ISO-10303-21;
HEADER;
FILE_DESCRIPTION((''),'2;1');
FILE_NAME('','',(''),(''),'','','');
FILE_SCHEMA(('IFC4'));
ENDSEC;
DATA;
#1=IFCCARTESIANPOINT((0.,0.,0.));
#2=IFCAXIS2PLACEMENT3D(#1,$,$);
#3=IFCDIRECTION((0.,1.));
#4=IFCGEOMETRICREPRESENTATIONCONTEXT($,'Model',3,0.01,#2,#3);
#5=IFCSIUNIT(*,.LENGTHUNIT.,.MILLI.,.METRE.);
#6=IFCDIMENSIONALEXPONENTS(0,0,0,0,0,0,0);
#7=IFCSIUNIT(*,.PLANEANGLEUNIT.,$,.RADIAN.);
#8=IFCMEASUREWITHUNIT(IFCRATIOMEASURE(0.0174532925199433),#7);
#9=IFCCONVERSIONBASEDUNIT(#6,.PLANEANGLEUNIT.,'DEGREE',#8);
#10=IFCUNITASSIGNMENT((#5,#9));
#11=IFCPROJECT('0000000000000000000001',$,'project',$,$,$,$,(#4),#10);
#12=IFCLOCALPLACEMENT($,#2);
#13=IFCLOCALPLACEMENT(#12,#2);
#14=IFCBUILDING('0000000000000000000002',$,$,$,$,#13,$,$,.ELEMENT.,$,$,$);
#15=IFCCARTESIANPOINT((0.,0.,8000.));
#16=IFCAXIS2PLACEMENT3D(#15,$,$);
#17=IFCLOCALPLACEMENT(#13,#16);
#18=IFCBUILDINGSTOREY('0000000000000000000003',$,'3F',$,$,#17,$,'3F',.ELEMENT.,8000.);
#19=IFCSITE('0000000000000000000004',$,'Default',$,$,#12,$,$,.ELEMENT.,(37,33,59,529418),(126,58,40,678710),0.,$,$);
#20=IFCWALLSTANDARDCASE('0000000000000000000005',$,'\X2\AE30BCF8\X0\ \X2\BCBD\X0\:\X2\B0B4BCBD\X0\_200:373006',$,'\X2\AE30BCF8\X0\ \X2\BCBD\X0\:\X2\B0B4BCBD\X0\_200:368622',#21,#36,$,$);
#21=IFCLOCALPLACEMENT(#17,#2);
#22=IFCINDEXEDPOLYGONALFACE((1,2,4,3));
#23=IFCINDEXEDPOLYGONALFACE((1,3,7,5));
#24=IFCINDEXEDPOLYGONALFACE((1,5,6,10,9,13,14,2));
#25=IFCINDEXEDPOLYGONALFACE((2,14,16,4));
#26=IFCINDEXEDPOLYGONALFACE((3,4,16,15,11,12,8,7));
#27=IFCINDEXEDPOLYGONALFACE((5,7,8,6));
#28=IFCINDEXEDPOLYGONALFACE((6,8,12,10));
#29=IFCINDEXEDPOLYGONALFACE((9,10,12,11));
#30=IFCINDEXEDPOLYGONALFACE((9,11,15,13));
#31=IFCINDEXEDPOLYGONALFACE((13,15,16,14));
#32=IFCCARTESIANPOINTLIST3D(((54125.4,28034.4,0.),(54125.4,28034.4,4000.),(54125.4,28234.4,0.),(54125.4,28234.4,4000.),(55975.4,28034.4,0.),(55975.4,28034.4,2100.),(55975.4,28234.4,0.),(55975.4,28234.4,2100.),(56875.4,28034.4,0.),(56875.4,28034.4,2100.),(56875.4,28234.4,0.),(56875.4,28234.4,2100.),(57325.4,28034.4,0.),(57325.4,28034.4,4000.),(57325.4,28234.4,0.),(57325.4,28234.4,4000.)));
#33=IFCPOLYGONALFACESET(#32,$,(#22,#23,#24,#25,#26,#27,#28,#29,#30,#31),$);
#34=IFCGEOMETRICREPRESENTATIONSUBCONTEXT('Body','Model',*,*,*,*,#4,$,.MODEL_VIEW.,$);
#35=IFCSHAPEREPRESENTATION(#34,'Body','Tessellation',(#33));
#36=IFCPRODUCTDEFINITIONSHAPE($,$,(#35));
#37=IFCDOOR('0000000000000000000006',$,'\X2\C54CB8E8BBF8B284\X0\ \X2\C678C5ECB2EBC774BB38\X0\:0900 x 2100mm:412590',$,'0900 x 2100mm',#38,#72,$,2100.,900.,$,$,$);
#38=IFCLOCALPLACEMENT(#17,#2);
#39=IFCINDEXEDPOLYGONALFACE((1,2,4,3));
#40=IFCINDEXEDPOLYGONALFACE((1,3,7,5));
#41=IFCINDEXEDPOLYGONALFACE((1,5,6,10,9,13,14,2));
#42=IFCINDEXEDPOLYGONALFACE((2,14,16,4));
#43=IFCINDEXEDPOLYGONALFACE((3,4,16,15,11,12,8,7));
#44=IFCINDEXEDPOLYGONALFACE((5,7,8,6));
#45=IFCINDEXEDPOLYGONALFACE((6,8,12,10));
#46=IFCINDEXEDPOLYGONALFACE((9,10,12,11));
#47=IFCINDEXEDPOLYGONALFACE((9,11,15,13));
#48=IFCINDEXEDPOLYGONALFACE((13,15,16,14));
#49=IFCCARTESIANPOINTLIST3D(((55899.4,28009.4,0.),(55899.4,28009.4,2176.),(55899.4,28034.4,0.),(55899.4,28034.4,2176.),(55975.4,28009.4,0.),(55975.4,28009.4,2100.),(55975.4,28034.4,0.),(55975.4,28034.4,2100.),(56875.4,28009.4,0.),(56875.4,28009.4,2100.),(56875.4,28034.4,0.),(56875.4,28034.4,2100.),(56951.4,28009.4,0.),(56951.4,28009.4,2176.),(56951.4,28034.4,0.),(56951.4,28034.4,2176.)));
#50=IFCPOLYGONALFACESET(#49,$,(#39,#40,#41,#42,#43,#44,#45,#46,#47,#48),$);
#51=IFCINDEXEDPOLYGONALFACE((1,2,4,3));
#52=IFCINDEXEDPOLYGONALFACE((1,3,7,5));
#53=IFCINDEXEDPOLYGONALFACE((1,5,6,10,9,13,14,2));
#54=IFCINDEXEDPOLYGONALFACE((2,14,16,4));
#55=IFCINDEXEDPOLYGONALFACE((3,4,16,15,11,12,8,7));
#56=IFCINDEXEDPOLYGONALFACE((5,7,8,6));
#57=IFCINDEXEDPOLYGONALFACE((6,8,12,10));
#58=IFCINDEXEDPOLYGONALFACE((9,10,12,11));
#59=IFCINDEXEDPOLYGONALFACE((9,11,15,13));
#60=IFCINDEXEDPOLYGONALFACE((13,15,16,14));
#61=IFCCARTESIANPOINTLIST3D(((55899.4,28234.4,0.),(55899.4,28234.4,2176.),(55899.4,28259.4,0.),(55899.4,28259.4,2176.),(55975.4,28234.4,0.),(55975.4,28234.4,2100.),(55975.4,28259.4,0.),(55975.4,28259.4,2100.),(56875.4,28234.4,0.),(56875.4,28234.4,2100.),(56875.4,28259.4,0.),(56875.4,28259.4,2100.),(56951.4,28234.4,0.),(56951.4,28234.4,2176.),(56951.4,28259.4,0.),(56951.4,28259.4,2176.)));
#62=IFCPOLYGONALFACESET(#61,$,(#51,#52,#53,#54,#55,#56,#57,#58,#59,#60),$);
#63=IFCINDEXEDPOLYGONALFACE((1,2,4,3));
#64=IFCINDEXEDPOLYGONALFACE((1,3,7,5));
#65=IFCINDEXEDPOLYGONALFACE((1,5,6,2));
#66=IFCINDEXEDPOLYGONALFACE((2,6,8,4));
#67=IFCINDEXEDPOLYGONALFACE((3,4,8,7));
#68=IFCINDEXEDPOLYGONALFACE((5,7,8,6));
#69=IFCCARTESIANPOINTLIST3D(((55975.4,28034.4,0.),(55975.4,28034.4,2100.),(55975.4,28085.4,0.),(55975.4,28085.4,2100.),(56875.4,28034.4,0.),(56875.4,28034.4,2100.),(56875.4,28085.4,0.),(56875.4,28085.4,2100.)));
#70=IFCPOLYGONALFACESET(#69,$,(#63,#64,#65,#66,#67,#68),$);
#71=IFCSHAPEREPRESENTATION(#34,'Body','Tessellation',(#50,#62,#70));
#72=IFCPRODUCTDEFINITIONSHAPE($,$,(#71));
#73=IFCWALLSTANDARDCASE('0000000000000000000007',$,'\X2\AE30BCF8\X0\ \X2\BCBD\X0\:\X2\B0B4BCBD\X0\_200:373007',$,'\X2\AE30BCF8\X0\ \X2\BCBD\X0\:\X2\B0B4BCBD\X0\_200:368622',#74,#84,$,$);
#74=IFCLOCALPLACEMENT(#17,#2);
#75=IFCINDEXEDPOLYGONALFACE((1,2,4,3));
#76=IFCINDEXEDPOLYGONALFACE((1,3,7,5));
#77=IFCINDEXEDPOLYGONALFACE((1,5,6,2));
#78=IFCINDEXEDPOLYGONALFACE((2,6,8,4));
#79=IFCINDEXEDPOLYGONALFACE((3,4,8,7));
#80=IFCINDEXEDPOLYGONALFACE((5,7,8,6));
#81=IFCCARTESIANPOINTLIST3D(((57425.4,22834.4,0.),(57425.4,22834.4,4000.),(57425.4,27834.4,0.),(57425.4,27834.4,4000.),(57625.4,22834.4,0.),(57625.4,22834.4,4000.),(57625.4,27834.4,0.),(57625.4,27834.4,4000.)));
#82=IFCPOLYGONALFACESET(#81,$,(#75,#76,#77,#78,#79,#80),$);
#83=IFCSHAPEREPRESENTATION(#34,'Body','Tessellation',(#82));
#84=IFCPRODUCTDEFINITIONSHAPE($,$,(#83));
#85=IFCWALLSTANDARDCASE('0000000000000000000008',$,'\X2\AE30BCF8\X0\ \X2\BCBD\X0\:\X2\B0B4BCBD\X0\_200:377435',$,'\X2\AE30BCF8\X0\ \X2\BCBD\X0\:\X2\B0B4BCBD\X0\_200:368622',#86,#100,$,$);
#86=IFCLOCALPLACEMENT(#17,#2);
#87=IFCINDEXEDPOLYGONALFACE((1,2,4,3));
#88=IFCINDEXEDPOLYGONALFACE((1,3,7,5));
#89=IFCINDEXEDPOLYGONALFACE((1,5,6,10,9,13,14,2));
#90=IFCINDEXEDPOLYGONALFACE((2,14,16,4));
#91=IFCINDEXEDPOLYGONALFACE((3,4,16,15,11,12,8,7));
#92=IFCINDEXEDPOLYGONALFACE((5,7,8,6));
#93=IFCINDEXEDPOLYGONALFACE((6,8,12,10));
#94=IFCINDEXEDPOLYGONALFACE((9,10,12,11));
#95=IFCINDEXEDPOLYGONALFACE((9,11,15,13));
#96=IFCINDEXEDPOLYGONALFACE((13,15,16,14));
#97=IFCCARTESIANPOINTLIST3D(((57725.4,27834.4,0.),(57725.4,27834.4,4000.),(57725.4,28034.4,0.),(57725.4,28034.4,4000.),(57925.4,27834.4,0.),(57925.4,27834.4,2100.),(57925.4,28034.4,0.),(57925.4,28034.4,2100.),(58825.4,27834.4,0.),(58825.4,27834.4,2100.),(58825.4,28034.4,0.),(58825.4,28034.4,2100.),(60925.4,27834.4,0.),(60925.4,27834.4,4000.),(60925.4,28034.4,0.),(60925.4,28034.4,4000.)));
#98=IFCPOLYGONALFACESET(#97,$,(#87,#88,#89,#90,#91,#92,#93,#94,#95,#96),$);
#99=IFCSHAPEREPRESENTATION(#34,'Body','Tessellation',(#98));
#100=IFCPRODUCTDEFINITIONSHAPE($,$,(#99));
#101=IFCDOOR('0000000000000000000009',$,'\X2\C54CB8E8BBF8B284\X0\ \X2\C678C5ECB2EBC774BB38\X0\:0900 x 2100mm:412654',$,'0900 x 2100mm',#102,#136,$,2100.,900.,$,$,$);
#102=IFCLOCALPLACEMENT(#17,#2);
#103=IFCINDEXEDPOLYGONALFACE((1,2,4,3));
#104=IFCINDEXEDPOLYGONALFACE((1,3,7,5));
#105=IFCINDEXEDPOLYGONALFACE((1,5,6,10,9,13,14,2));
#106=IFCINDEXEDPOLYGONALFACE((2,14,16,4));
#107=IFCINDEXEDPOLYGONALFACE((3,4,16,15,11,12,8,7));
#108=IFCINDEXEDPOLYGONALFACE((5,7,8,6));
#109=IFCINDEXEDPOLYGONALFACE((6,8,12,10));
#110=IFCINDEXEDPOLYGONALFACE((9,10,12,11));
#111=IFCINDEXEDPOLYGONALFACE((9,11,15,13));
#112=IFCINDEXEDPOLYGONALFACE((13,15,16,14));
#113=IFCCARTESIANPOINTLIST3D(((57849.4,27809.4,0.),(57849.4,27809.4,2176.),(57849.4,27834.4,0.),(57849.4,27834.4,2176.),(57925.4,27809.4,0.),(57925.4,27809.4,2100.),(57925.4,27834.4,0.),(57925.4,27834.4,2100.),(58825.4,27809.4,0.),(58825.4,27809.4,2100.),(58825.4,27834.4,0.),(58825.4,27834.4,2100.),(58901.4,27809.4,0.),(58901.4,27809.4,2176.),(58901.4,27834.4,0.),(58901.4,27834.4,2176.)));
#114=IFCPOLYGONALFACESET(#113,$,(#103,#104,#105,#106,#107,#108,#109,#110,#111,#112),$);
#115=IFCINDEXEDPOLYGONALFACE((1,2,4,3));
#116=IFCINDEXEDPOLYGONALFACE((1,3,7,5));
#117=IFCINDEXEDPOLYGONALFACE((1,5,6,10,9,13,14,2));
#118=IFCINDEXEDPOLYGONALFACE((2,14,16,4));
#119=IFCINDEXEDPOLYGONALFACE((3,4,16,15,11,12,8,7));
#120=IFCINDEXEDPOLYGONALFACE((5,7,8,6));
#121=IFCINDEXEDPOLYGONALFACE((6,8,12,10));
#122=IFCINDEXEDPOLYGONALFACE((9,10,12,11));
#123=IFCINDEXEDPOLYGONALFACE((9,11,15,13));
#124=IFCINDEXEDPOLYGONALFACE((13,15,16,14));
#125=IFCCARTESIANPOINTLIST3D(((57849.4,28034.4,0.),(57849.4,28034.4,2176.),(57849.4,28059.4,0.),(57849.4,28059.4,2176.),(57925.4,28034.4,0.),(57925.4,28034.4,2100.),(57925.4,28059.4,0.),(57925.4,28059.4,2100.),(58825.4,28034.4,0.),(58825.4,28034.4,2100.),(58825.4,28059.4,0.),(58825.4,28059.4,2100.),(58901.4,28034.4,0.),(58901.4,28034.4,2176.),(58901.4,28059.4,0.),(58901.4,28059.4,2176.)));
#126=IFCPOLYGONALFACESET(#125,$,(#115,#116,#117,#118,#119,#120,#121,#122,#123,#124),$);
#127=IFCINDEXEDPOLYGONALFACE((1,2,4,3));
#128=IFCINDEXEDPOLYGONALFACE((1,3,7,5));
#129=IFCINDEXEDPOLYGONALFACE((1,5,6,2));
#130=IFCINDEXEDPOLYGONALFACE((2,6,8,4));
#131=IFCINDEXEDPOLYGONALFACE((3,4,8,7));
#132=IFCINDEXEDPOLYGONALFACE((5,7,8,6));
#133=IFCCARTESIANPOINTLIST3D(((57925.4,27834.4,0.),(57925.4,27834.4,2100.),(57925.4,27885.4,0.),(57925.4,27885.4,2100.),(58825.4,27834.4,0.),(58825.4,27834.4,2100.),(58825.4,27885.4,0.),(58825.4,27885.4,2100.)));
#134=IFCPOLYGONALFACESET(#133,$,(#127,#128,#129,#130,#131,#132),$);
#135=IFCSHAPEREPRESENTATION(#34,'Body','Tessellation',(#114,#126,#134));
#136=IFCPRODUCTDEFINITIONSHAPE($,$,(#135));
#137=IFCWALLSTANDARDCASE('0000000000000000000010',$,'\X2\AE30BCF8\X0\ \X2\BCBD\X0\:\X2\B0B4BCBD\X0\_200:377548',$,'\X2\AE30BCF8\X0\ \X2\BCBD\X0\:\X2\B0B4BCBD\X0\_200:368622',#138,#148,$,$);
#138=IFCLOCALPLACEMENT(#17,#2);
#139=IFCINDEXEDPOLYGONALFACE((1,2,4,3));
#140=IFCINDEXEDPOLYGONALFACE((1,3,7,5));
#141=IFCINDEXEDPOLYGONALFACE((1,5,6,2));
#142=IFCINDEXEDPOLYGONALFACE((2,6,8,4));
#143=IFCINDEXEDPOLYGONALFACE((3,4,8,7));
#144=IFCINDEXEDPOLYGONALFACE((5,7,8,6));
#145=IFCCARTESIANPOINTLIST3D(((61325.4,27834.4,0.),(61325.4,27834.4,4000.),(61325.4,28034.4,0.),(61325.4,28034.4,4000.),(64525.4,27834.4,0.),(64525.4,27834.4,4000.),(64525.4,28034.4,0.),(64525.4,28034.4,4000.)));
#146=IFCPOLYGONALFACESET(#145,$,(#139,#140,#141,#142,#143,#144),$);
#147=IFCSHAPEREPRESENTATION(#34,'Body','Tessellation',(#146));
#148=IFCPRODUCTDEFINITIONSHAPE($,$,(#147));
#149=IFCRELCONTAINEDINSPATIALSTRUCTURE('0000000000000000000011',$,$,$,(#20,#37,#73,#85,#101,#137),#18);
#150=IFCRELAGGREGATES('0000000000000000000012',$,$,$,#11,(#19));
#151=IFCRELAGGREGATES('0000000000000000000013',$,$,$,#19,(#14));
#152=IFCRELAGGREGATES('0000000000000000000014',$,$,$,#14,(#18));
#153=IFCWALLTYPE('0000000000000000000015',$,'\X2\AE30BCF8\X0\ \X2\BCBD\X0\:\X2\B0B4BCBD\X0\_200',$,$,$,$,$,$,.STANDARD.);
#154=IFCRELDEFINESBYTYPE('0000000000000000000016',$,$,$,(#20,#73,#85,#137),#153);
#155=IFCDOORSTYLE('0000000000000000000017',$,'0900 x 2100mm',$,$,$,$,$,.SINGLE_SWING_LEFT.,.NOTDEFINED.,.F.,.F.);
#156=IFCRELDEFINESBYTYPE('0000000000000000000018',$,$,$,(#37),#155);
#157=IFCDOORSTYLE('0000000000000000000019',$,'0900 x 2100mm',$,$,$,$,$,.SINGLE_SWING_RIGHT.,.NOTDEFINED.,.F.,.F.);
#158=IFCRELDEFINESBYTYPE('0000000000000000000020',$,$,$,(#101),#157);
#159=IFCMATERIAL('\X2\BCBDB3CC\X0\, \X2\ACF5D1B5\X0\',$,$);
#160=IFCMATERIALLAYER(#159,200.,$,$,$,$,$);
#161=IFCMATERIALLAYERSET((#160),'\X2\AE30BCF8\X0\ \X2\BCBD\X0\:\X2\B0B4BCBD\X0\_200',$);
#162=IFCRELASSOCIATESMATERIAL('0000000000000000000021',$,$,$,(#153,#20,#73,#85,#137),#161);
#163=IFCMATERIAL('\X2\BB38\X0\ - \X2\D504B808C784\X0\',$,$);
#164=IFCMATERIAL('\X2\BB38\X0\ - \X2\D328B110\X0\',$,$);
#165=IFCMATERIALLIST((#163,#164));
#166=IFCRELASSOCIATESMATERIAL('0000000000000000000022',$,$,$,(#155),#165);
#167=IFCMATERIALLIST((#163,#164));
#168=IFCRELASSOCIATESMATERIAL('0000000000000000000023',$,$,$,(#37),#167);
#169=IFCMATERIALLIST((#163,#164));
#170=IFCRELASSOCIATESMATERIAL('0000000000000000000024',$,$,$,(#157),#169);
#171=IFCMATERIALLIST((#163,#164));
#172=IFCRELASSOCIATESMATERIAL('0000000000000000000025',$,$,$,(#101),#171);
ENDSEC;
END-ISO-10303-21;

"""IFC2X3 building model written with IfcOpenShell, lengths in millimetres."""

from ifc_helpers import new_model, entity, si_unit, converted_unit, direction, frame, frame_2d, origin, place, context, subcontext, project, spatial, polyline, rectangle, outline, extrude, source, transform, mapped, material, material_list, layer, layer_set, layer_usage, type_object, type_shapes, element, fill, save


model = new_model("IFC2X3")

# Units and contexts
model_context = context("Model", 3, precision=0.01, world=origin(), true_north=direction((0.0, 1.0)))
body_context = subcontext(model_context, "Body", "Model", "MODEL_VIEW")
ifc_project = project(units=[si_unit("LENGTHUNIT", "METRE", prefix="MILLI"), converted_unit("PLANEANGLEUNIT", "DEGREE", entity("IfcRatioMeasure", 0.0174532925199433), si_unit("PLANEANGLEUNIT", "RADIAN"), dimensions=[0, 0, 0, 0, 0, 0, 0])], contexts=[model_context])

# Site, building, storey
site_placement = place(None, origin())
site = spatial("IfcSite", under=ifc_project, at=site_placement, Name="Default", CompositionType="ELEMENT", RefLatitude=(37, 33, 59, 529418), RefLongitude=(126, 58, 40, 678710), RefElevation=0.0)
building_placement = place(site_placement, origin())
building = spatial("IfcBuilding", under=site, at=building_placement, CompositionType="ELEMENT")
storey_placement = place(building_placement, frame((0.0, 0.0, 8000.0)))
storey = spatial("IfcBuildingStorey", under=building, at=storey_placement, Name="3F", LongName="3F", CompositionType="ELEMENT", Elevation=8000.0)

# Wall, opening, door
ifc_material_1 = material(Name="벽돌, 공통")
ifc_layer_1 = layer(ifc_material_1, 200.0)
ifc_layer_set_1 = layer_set([ifc_layer_1], Name="기본 벽:내벽_200")
ifc_layer_usage_1 = layer_usage(ifc_layer_set_1, "AXIS2", "NEGATIVE", 100.0)
wall_type_1 = type_object("IfcWallType", Name="기본 벽:내벽_200", PredefinedType="STANDARD", material=ifc_layer_set_1)
wall_1_placement = place(storey_placement, frame((57325.4, 28134.4, 0.0), z_axis=(0.0, 0.0, 1.0), x_axis=(-1.0, 0.0, 0.0)))
wall_1 = element("IfcWallStandardCase", 1, at=wall_1_placement, inside=storey, type_object=wall_type_1, material=ifc_layer_usage_1, Name="기본 벽:내벽_200:373006", ObjectType="기본 벽:내벽_200:368622", context=body_context, shape_type="SweptSolid", body=[
    extrude(rectangle(XDim=3200.0, YDim=200.0, at=frame_2d((1600.0, 0.0), x_axis=(-1.0, 0.0))), origin(), (0.0, 0.0, 1.0), 4000.0),
])
opening_1_placement = place(wall_1_placement, frame((450.0, -100.0, 0.0)))
opening_1 = element("IfcOpeningElement", 2, at=opening_1_placement, cuts=wall_1, ObjectType="Opening", context=body_context, shape_type="SweptSolid", body=[
    extrude(rectangle(XDim=900.0, YDim=2100.0, at=frame_2d((1050.0, 450.0), x_axis=(0.0, -1.0))), frame((0.0, 0.0, 0.0), z_axis=(0.0, 1.0, 0.0), x_axis=(0.0, 0.0, 1.0)), (0.0, 0.0, 1.0), 200.0),
])
ifc_material_2 = material(Name="문 - 프레임")
ifc_material_3 = material(Name="문 - 패널")
ifc_material_list_1 = material_list([ifc_material_2, ifc_material_3])
ifc_material_list_2 = material_list([ifc_material_2, ifc_material_3])
door_style_1 = type_object("IfcDoorStyle", Name="0900 x 2100mm", ConstructionType="NOTDEFINED", OperationType="SINGLE_SWING_LEFT", ParameterTakesPrecedence=False, Sizeable=False, material=ifc_material_list_2)
shared_shape_1 = source(origin(), body_context, "Body", "SweptSolid", [
    extrude(outline(polyline([(-526.0, -1107.0), (526.0, -1107.0), (526.0, 1069.0), (450.0, 1069.0), (450.0, -1031.0), (-450.0, -1031.0), (-450.0, 1069.0), (-526.0, 1069.0), (-526.0, -1107.0)])), frame((450.0, 225.0, 1069.0), z_axis=(0.0, -1.0, 0.0), x_axis=(-1.0, 0.0, 0.0)), (0.0, 0.0, 1.0), 25.0),
    extrude(outline(polyline([(-1107.0, -526.0), (1069.0, -526.0), (1069.0, -450.0), (-1031.0, -450.0), (-1031.0, 450.0), (1069.0, 450.0), (1069.0, 526.0), (-1107.0, 526.0), (-1107.0, -526.0)])), frame((450.0, 0.0, 1069.0), z_axis=(0.0, -1.0, 0.0), x_axis=(0.0, 0.0, -1.0)), (0.0, 0.0, 1.0), 25.0),
    extrude(rectangle(XDim=900.0, YDim=51.0, at=frame_2d((0.0, 0.0), x_axis=(1.0, 0.0))), frame((450.0, 174.5, 0.0)), (0.0, 0.0, 1.0), 2100.0),
])
type_shapes(door_style_1, [shared_shape_1])
door_1_placement = place(opening_1_placement, frame((0.0, 0.0, 0.0)))
door_1 = element("IfcDoor", 3, at=door_1_placement, inside=storey, type_object=door_style_1, material=ifc_material_list_1, Name="알루미늄 외여닫이문:0900 x 2100mm:412590", ObjectType="0900 x 2100mm", OverallHeight=2100.0, OverallWidth=900.0, context=body_context, shape_type="MappedRepresentation", body=[
    mapped(shared_shape_1, transform((0.0, 0.0, 0.0), scale=1.0)),
])
fill(opening_1, door_1)

# Wall
ifc_layer_usage_2 = layer_usage(ifc_layer_set_1, "AXIS2", "NEGATIVE", 100.0)
wall_2_placement = place(storey_placement, frame((57525.4, 27834.4, 0.0), z_axis=(0.0, 0.0, 1.0), x_axis=(0.0, -1.0, 0.0)))
element("IfcWallStandardCase", 4, at=wall_2_placement, inside=storey, type_object=wall_type_1, material=ifc_layer_usage_2, Name="기본 벽:내벽_200:373007", ObjectType="기본 벽:내벽_200:368622", context=body_context, shape_type="SweptSolid", body=[
    extrude(rectangle(XDim=5000.0, YDim=200.0, at=frame_2d((2500.0, 0.0), x_axis=(-1.0, 0.0))), origin(), (0.0, 0.0, 1.0), 4000.0),
])

# Wall, opening, door
ifc_layer_usage_3 = layer_usage(ifc_layer_set_1, "AXIS2", "NEGATIVE", 100.0)
wall_3_placement = place(storey_placement, frame((57725.4, 27934.4, 0.0)))
wall_3 = element("IfcWallStandardCase", 5, at=wall_3_placement, inside=storey, type_object=wall_type_1, material=ifc_layer_usage_3, Name="기본 벽:내벽_200:377435", ObjectType="기본 벽:내벽_200:368622", context=body_context, shape_type="SweptSolid", body=[
    extrude(rectangle(XDim=3200.0, YDim=200.0, at=frame_2d((1600.0, 0.0), x_axis=(-1.0, 0.0))), origin(), (0.0, 0.0, 1.0), 4000.0),
])
opening_2_placement = place(wall_3_placement, frame((1100.0, 100.0, 0.0)))
opening_2 = element("IfcOpeningElement", 6, at=opening_2_placement, cuts=wall_3, ObjectType="Opening", context=body_context, shape_type="SweptSolid", body=[
    extrude(rectangle(XDim=900.0, YDim=2100.0, at=frame_2d((1050.0, 450.0), x_axis=(0.0, 1.0))), frame((0.0, 0.0, 0.0), z_axis=(0.0, -1.0, 0.0), x_axis=(0.0, 0.0, 1.0)), (0.0, 0.0, 1.0), 200.0),
])
ifc_material_list_3 = material_list([ifc_material_2, ifc_material_3])
ifc_material_list_4 = material_list([ifc_material_2, ifc_material_3])
door_style_2 = type_object("IfcDoorStyle", Name="0900 x 2100mm", ConstructionType="NOTDEFINED", OperationType="SINGLE_SWING_RIGHT", ParameterTakesPrecedence=False, Sizeable=False, material=ifc_material_list_4)
shared_shape_2 = source(origin(), body_context, "Body", "SweptSolid", [
    extrude(outline(polyline([(-526.0, -1107.0), (526.0, -1107.0), (526.0, 1069.0), (450.0, 1069.0), (450.0, -1031.0), (-450.0, -1031.0), (-450.0, 1069.0), (-526.0, 1069.0), (-526.0, -1107.0)])), frame((450.0, 200.0, 1069.0), z_axis=(0.0, 1.0, 0.0), x_axis=(1.0, 0.0, 0.0)), (0.0, 0.0, 1.0), 25.0),
    extrude(outline(polyline([(-1107.0, -526.0), (1069.0, -526.0), (1069.0, -450.0), (-1031.0, -450.0), (-1031.0, 450.0), (1069.0, 450.0), (1069.0, 526.0), (-1107.0, 526.0), (-1107.0, -526.0)])), frame((450.0, -25.0, 1069.0), z_axis=(0.0, 1.0, 0.0), x_axis=(0.0, 0.0, -1.0)), (0.0, 0.0, 1.0), 25.0),
    extrude(rectangle(XDim=51.0, YDim=900.0, at=frame_2d((0.0, 0.0), x_axis=(1.0, 0.0))), frame((450.0, 174.5, 0.0), z_axis=(0.0, 0.0, 1.0), x_axis=(0.0, 1.0, 0.0)), (0.0, 0.0, 1.0), 2100.0),
])
type_shapes(door_style_2, [shared_shape_2])
door_2_placement = place(opening_2_placement, frame((0.0, 0.0, 0.0), z_axis=(0.0, 0.0, 1.0), x_axis=(-1.0, 0.0, 0.0)))
door_2 = element("IfcDoor", 7, at=door_2_placement, inside=storey, type_object=door_style_2, material=ifc_material_list_3, Name="알루미늄 외여닫이문:0900 x 2100mm:412654", ObjectType="0900 x 2100mm", OverallHeight=2100.0, OverallWidth=900.0, context=body_context, shape_type="MappedRepresentation", body=[
    mapped(shared_shape_2, transform((0.0, 0.0, 0.0), scale=1.0)),
])
fill(opening_2, door_2)

# Wall
ifc_layer_usage_4 = layer_usage(ifc_layer_set_1, "AXIS2", "NEGATIVE", 100.0)
wall_4_placement = place(storey_placement, frame((61325.4, 27934.4, 0.0)))
element("IfcWallStandardCase", 8, at=wall_4_placement, inside=storey, type_object=wall_type_1, material=ifc_layer_usage_4, Name="기본 벽:내벽_200:377548", ObjectType="기본 벽:내벽_200:368622", context=body_context, shape_type="SweptSolid", body=[
    extrude(rectangle(XDim=3200.0, YDim=200.0, at=frame_2d((1600.0, 0.0), x_axis=(-1.0, 0.0))), origin(), (0.0, 0.0, 1.0), 4000.0),
])

save(model, "model.ifc")
